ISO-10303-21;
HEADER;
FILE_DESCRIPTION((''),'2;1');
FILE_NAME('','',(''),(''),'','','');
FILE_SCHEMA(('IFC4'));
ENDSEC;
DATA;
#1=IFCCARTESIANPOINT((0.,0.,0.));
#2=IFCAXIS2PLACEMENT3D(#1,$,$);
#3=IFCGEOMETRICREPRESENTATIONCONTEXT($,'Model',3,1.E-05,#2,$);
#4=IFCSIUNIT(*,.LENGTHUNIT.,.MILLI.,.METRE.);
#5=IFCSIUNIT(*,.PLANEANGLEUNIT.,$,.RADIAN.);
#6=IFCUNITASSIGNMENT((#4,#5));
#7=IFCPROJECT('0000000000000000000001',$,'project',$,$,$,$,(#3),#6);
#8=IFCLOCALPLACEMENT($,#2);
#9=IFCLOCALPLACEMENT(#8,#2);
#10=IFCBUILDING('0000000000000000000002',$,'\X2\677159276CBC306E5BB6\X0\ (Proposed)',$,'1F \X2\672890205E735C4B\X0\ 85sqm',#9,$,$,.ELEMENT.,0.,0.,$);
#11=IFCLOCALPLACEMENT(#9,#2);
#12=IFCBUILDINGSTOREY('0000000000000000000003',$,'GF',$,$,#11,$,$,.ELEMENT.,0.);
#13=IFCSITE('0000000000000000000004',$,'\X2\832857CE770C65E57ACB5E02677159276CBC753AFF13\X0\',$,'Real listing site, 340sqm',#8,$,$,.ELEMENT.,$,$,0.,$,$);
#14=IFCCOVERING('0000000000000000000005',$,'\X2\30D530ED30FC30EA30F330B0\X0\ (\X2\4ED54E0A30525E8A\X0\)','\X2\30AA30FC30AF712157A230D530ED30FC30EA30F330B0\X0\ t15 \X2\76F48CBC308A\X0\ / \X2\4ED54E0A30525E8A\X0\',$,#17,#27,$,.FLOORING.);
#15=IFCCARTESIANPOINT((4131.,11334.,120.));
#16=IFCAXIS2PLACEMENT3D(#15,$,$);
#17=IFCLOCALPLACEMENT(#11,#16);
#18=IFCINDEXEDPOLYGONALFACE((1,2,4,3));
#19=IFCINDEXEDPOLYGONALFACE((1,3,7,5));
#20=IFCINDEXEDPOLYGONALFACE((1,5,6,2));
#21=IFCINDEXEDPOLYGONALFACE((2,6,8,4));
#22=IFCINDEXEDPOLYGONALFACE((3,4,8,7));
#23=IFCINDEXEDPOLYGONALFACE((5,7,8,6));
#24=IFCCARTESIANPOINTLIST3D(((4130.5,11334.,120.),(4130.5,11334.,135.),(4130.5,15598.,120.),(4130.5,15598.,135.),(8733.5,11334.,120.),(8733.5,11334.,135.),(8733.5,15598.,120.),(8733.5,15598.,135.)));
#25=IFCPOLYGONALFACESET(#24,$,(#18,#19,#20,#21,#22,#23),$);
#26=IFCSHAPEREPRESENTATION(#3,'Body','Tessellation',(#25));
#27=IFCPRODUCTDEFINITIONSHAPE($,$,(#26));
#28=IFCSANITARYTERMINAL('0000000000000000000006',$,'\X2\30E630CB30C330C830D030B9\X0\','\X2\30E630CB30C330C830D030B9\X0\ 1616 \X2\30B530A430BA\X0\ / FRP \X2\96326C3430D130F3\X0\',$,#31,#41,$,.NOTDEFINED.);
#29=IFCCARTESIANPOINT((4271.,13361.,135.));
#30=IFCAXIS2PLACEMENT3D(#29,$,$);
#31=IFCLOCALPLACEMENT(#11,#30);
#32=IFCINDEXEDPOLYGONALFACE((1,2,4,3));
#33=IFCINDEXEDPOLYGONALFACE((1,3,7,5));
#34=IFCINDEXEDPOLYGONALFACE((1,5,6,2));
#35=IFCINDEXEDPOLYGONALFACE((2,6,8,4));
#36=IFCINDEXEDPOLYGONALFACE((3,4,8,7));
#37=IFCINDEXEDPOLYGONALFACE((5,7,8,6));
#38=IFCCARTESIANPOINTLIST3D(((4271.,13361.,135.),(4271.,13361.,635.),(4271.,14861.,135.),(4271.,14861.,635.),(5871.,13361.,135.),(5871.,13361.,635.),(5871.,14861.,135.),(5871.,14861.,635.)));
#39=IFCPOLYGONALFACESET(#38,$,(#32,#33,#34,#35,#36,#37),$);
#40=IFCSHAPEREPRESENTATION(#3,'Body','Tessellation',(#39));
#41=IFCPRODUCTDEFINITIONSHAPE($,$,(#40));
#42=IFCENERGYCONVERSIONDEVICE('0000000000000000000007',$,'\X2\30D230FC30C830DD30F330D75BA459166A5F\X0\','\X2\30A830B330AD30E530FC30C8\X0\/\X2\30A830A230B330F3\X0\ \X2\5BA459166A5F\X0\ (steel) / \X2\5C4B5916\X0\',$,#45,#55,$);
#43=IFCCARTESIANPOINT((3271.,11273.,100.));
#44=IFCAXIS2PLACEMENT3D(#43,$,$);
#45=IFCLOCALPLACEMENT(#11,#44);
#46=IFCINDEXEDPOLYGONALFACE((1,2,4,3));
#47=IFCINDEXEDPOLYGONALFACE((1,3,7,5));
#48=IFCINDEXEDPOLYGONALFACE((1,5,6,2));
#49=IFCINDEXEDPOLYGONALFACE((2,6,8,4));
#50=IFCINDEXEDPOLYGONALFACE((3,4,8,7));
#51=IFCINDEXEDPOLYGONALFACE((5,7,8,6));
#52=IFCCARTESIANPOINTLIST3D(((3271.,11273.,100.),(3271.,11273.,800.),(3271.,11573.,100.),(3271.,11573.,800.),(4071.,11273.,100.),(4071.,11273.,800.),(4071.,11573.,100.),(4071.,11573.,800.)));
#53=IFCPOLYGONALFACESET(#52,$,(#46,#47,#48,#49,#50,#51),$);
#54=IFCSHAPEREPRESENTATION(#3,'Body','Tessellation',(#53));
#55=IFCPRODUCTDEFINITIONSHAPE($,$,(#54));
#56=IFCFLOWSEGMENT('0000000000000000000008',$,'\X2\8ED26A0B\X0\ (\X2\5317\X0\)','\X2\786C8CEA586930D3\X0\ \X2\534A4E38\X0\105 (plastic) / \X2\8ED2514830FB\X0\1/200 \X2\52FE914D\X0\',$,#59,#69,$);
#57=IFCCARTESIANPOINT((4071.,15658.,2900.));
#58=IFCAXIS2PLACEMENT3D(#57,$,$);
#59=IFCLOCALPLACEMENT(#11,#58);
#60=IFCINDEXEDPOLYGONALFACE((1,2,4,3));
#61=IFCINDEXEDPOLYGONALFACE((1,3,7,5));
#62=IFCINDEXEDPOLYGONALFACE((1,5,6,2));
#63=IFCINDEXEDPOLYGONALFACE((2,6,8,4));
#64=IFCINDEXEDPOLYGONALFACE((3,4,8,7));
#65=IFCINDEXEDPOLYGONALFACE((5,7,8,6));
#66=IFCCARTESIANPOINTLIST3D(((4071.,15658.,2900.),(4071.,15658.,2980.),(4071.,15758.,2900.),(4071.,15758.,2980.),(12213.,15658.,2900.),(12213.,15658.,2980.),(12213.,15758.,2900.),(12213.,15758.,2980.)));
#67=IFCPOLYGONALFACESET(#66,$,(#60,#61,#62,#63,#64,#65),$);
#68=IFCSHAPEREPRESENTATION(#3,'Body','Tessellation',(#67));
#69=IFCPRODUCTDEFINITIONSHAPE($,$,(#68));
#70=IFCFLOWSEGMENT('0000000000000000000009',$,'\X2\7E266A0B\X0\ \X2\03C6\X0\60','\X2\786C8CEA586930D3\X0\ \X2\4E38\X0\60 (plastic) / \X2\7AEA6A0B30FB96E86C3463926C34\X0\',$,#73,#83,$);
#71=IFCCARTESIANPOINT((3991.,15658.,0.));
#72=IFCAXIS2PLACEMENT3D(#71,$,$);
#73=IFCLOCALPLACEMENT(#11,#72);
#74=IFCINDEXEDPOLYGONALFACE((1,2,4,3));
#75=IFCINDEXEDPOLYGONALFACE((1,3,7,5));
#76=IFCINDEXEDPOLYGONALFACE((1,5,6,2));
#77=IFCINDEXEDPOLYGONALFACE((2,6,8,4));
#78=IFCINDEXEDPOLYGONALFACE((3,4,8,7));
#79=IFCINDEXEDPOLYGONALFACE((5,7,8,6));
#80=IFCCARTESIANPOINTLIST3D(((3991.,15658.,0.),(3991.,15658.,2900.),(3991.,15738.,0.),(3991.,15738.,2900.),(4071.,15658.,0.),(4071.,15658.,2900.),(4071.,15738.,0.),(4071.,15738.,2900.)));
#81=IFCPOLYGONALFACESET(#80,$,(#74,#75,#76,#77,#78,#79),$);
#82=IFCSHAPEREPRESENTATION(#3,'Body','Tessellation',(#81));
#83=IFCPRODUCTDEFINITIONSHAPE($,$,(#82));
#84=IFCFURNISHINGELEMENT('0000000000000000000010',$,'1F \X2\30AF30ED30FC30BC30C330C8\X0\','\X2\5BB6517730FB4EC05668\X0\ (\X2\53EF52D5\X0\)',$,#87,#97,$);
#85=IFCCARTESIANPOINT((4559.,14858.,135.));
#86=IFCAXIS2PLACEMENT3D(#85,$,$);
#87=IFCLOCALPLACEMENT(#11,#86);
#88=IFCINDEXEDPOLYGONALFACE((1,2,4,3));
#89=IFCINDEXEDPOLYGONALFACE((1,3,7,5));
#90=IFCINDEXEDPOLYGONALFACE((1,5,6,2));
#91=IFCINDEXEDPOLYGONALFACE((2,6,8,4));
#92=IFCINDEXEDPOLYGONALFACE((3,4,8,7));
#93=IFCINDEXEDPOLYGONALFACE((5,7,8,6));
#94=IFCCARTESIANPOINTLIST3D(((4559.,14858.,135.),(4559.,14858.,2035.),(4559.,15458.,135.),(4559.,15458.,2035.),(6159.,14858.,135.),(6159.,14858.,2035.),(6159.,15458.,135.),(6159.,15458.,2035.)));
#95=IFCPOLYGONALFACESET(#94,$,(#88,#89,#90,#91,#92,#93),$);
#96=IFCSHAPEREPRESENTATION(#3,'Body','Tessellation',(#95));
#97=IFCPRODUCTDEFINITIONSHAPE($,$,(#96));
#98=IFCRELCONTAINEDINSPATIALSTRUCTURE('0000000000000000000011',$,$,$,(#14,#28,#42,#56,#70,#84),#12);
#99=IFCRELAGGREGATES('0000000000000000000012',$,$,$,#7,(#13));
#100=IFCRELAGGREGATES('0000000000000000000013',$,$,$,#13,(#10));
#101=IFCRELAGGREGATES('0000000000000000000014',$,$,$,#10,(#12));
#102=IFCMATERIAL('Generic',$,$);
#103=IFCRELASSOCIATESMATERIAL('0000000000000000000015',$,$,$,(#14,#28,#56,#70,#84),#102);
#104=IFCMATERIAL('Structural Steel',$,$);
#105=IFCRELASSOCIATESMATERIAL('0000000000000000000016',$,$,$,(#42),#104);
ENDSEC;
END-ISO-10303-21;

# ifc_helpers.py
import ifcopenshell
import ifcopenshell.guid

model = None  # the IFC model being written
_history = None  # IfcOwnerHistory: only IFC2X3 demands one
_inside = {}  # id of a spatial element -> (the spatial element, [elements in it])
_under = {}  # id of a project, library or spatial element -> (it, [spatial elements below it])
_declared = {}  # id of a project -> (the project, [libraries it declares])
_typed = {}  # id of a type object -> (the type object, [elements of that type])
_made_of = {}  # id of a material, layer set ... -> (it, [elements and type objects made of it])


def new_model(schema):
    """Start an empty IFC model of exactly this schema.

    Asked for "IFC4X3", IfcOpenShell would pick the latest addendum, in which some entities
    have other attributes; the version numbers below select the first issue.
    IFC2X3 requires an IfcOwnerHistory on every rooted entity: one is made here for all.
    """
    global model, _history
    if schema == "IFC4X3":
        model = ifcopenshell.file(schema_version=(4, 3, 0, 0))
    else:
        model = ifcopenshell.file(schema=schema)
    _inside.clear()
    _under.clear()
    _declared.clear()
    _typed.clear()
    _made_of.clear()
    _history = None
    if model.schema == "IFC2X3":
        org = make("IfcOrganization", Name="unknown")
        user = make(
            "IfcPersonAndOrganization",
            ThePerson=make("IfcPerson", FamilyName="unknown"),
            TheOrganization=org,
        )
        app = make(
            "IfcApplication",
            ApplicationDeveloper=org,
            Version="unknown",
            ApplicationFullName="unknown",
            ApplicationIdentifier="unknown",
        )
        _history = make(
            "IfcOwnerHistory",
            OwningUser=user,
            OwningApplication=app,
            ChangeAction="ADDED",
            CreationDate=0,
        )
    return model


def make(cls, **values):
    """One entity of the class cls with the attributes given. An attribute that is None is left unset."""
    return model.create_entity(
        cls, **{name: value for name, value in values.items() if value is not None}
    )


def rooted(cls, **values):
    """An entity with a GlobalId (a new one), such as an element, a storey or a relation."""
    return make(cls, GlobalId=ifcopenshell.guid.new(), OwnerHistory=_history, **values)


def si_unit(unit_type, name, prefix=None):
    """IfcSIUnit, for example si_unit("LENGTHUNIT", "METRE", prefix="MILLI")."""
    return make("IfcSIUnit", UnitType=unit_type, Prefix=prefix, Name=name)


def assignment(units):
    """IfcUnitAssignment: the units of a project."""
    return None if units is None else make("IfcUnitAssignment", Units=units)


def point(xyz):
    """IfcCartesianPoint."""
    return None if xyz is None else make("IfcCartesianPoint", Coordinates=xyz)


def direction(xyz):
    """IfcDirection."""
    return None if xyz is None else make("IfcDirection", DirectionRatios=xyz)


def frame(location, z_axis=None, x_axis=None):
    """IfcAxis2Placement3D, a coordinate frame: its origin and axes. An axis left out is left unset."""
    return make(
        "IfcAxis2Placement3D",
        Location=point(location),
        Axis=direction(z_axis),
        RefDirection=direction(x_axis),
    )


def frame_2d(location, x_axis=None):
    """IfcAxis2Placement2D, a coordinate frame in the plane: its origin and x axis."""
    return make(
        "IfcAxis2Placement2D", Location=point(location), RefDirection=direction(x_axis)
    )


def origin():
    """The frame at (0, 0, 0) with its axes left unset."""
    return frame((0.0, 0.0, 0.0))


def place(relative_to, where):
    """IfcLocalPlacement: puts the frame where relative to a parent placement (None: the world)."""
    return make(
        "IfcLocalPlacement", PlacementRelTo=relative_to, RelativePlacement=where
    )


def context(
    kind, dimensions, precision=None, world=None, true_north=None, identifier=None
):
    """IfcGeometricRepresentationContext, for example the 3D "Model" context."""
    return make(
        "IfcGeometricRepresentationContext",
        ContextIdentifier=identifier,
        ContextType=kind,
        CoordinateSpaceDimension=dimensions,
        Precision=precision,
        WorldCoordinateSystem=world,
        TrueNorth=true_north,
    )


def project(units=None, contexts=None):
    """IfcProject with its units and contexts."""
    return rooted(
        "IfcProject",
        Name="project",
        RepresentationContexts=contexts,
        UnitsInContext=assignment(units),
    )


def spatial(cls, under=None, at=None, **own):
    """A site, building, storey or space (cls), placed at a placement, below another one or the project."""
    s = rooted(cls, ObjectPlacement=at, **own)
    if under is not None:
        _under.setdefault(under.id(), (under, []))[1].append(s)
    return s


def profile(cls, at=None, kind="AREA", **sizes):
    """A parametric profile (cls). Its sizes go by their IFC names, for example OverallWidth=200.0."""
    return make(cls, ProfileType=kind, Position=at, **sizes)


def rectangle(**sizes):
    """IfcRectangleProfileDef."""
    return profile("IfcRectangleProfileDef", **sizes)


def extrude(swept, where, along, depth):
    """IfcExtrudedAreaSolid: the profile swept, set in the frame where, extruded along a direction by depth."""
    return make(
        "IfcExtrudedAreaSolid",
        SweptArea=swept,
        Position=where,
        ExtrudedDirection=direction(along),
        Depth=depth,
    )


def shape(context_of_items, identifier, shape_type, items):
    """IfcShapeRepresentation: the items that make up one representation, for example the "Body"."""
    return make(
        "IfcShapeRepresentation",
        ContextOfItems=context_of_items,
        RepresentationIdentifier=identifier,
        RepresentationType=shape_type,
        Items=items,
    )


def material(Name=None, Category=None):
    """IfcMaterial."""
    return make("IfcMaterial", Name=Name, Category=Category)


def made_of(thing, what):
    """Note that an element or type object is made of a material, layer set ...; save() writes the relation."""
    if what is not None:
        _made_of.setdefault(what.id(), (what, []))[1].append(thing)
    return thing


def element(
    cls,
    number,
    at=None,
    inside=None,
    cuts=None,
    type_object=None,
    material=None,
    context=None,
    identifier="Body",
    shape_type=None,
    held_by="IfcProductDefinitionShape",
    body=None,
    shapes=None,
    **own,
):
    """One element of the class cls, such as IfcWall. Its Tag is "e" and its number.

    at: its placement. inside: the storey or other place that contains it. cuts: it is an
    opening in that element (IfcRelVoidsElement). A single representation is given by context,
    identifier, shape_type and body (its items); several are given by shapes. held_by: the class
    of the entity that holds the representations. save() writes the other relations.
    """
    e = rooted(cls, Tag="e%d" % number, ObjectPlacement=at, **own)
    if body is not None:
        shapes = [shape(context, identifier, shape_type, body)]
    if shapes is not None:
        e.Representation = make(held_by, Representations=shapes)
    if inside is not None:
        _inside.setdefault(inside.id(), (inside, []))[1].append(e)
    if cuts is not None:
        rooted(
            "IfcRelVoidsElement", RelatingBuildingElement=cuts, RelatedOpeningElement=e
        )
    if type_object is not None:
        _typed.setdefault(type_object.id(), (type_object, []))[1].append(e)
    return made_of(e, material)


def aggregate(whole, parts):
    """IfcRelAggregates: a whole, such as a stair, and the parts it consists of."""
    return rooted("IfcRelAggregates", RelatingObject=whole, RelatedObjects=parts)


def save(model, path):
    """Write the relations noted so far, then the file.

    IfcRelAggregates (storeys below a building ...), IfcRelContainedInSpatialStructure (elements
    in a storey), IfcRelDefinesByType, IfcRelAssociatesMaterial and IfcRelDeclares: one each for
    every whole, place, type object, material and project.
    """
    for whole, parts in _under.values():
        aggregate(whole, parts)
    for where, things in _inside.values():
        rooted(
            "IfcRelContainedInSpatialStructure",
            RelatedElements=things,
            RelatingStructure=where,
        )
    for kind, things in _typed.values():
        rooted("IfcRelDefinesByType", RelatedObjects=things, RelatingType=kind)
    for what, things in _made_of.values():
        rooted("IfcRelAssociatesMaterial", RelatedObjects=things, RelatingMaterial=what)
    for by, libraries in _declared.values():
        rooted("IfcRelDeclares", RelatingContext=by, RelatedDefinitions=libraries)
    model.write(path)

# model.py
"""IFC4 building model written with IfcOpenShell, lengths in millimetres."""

from ifc_helpers import new_model, si_unit, frame, frame_2d, origin, place, context, project, spatial, rectangle, extrude, material, element, save


model = new_model("IFC4")

# Units and contexts
model_context = context("Model", 3, precision=1e-05, world=origin())
ifc_project = project(units=[si_unit("LENGTHUNIT", "METRE", prefix="MILLI"), si_unit("PLANEANGLEUNIT", "RADIAN")], contexts=[model_context])

# Site, building, storey
site_placement = place(None, origin())
site = spatial("IfcSite", under=ifc_project, at=site_placement, Name="茨城県日立市東大沼町３", ObjectType="Real listing site, 340sqm", CompositionType="ELEMENT", RefElevation=0.0)
building_placement = place(site_placement, origin())
building = spatial("IfcBuilding", under=site, at=building_placement, Name="東大沼の家 (Proposed)", ObjectType="1F 木造平屋 85sqm", CompositionType="ELEMENT", ElevationOfRefHeight=0.0, ElevationOfTerrain=0.0)
storey_placement = place(building_placement, origin())
storey = spatial("IfcBuildingStorey", under=building, at=storey_placement, Name="GF", CompositionType="ELEMENT", Elevation=0.0)

# Shared definitions
ifc_material_1 = material(Name="Structural Steel")

# Covering
ifc_material_2 = material(Name="Generic")
covering_placement = place(storey_placement, frame((4131.0, 11334.0, 120.0)))
element("IfcCovering", 1, at=covering_placement, inside=storey, material=ifc_material_2, Name="フローリング (仕上げ床)", Description="オーク無垢フローリング t15 直貼り / 仕上げ床", PredefinedType="FLOORING", context=model_context, shape_type="SweptSolid", body=[
    extrude(rectangle(XDim=4603.0, YDim=4264.0, at=frame_2d((2301.0, 2132.0))), frame((4131.0, 11334.0, 120.0)), (0.0, 0.0, 1.0), 15.0),
])

# Sanitary terminal
sanitary_terminal_placement = place(storey_placement, frame((4271.0, 13361.0, 135.0)))
element("IfcSanitaryTerminal", 2, at=sanitary_terminal_placement, inside=storey, material=ifc_material_2, Name="ユニットバス", Description="ユニットバス 1616 サイズ / FRP 防水パン", PredefinedType="NOTDEFINED", context=model_context, shape_type="SweptSolid", body=[
    extrude(rectangle(XDim=1600.0, YDim=1500.0, at=frame_2d((800.0, 750.0))), frame((4271.0, 13361.0, 135.0)), (0.0, 0.0, 1.0), 500.0),
])

# Energy conversion device
energy_conversion_device_placement = place(storey_placement, frame((3271.0, 11273.0, 100.0)))
element("IfcEnergyConversionDevice", 3, at=energy_conversion_device_placement, inside=storey, material=ifc_material_1, Name="ヒートポンプ室外機", Description="エコキュート/エアコン 室外機 (steel) / 屋外", context=model_context, shape_type="SweptSolid", body=[
    extrude(rectangle(XDim=800.0, YDim=300.0, at=frame_2d((400.0, 150.0))), frame((3271.0, 11273.0, 100.0)), (0.0, 0.0, 1.0), 700.0),
])

# Flow segments
flow_segment_1_placement = place(storey_placement, frame((4071.0, 15658.0, 2900.0)))
element("IfcFlowSegment", 4, at=flow_segment_1_placement, inside=storey, material=ifc_material_2, Name="軒樋 (北)", Description="硬質塩ビ 半丸105 (plastic) / 軒先・1/200 勾配", context=model_context, shape_type="SweptSolid", body=[
    extrude(rectangle(XDim=8142.0, YDim=100.0, at=frame_2d((4071.0, 50.0))), frame((4071.0, 15658.0, 2900.0)), (0.0, 0.0, 1.0), 80.0),
])
flow_segment_2_placement = place(storey_placement, frame((3991.0, 15658.0, 0.0)))
element("IfcFlowSegment", 5, at=flow_segment_2_placement, inside=storey, material=ifc_material_2, Name="縦樋 φ60", Description="硬質塩ビ 丸60 (plastic) / 竪樋・雨水排水", context=model_context, shape_type="SweptSolid", body=[
    extrude(rectangle(XDim=80.0, YDim=80.0, at=frame_2d((40.0, 40.0))), frame((3991.0, 15658.0, 0.0)), (0.0, 0.0, 1.0), 2900.0),
])

# Furnishing element
furnishing_placement = place(storey_placement, frame((4559.0, 14858.0, 135.0)))
element("IfcFurnishingElement", 6, at=furnishing_placement, inside=storey, material=ifc_material_2, Name="1F クローゼット", Description="家具・什器 (可動)", context=model_context, shape_type="SweptSolid", body=[
    extrude(rectangle(XDim=1600.0, YDim=600.0, at=frame_2d((800.0, 300.0))), frame((4559.0, 14858.0, 135.0)), (0.0, 0.0, 1.0), 1900.0),
])

save(model, "model.ifc")
